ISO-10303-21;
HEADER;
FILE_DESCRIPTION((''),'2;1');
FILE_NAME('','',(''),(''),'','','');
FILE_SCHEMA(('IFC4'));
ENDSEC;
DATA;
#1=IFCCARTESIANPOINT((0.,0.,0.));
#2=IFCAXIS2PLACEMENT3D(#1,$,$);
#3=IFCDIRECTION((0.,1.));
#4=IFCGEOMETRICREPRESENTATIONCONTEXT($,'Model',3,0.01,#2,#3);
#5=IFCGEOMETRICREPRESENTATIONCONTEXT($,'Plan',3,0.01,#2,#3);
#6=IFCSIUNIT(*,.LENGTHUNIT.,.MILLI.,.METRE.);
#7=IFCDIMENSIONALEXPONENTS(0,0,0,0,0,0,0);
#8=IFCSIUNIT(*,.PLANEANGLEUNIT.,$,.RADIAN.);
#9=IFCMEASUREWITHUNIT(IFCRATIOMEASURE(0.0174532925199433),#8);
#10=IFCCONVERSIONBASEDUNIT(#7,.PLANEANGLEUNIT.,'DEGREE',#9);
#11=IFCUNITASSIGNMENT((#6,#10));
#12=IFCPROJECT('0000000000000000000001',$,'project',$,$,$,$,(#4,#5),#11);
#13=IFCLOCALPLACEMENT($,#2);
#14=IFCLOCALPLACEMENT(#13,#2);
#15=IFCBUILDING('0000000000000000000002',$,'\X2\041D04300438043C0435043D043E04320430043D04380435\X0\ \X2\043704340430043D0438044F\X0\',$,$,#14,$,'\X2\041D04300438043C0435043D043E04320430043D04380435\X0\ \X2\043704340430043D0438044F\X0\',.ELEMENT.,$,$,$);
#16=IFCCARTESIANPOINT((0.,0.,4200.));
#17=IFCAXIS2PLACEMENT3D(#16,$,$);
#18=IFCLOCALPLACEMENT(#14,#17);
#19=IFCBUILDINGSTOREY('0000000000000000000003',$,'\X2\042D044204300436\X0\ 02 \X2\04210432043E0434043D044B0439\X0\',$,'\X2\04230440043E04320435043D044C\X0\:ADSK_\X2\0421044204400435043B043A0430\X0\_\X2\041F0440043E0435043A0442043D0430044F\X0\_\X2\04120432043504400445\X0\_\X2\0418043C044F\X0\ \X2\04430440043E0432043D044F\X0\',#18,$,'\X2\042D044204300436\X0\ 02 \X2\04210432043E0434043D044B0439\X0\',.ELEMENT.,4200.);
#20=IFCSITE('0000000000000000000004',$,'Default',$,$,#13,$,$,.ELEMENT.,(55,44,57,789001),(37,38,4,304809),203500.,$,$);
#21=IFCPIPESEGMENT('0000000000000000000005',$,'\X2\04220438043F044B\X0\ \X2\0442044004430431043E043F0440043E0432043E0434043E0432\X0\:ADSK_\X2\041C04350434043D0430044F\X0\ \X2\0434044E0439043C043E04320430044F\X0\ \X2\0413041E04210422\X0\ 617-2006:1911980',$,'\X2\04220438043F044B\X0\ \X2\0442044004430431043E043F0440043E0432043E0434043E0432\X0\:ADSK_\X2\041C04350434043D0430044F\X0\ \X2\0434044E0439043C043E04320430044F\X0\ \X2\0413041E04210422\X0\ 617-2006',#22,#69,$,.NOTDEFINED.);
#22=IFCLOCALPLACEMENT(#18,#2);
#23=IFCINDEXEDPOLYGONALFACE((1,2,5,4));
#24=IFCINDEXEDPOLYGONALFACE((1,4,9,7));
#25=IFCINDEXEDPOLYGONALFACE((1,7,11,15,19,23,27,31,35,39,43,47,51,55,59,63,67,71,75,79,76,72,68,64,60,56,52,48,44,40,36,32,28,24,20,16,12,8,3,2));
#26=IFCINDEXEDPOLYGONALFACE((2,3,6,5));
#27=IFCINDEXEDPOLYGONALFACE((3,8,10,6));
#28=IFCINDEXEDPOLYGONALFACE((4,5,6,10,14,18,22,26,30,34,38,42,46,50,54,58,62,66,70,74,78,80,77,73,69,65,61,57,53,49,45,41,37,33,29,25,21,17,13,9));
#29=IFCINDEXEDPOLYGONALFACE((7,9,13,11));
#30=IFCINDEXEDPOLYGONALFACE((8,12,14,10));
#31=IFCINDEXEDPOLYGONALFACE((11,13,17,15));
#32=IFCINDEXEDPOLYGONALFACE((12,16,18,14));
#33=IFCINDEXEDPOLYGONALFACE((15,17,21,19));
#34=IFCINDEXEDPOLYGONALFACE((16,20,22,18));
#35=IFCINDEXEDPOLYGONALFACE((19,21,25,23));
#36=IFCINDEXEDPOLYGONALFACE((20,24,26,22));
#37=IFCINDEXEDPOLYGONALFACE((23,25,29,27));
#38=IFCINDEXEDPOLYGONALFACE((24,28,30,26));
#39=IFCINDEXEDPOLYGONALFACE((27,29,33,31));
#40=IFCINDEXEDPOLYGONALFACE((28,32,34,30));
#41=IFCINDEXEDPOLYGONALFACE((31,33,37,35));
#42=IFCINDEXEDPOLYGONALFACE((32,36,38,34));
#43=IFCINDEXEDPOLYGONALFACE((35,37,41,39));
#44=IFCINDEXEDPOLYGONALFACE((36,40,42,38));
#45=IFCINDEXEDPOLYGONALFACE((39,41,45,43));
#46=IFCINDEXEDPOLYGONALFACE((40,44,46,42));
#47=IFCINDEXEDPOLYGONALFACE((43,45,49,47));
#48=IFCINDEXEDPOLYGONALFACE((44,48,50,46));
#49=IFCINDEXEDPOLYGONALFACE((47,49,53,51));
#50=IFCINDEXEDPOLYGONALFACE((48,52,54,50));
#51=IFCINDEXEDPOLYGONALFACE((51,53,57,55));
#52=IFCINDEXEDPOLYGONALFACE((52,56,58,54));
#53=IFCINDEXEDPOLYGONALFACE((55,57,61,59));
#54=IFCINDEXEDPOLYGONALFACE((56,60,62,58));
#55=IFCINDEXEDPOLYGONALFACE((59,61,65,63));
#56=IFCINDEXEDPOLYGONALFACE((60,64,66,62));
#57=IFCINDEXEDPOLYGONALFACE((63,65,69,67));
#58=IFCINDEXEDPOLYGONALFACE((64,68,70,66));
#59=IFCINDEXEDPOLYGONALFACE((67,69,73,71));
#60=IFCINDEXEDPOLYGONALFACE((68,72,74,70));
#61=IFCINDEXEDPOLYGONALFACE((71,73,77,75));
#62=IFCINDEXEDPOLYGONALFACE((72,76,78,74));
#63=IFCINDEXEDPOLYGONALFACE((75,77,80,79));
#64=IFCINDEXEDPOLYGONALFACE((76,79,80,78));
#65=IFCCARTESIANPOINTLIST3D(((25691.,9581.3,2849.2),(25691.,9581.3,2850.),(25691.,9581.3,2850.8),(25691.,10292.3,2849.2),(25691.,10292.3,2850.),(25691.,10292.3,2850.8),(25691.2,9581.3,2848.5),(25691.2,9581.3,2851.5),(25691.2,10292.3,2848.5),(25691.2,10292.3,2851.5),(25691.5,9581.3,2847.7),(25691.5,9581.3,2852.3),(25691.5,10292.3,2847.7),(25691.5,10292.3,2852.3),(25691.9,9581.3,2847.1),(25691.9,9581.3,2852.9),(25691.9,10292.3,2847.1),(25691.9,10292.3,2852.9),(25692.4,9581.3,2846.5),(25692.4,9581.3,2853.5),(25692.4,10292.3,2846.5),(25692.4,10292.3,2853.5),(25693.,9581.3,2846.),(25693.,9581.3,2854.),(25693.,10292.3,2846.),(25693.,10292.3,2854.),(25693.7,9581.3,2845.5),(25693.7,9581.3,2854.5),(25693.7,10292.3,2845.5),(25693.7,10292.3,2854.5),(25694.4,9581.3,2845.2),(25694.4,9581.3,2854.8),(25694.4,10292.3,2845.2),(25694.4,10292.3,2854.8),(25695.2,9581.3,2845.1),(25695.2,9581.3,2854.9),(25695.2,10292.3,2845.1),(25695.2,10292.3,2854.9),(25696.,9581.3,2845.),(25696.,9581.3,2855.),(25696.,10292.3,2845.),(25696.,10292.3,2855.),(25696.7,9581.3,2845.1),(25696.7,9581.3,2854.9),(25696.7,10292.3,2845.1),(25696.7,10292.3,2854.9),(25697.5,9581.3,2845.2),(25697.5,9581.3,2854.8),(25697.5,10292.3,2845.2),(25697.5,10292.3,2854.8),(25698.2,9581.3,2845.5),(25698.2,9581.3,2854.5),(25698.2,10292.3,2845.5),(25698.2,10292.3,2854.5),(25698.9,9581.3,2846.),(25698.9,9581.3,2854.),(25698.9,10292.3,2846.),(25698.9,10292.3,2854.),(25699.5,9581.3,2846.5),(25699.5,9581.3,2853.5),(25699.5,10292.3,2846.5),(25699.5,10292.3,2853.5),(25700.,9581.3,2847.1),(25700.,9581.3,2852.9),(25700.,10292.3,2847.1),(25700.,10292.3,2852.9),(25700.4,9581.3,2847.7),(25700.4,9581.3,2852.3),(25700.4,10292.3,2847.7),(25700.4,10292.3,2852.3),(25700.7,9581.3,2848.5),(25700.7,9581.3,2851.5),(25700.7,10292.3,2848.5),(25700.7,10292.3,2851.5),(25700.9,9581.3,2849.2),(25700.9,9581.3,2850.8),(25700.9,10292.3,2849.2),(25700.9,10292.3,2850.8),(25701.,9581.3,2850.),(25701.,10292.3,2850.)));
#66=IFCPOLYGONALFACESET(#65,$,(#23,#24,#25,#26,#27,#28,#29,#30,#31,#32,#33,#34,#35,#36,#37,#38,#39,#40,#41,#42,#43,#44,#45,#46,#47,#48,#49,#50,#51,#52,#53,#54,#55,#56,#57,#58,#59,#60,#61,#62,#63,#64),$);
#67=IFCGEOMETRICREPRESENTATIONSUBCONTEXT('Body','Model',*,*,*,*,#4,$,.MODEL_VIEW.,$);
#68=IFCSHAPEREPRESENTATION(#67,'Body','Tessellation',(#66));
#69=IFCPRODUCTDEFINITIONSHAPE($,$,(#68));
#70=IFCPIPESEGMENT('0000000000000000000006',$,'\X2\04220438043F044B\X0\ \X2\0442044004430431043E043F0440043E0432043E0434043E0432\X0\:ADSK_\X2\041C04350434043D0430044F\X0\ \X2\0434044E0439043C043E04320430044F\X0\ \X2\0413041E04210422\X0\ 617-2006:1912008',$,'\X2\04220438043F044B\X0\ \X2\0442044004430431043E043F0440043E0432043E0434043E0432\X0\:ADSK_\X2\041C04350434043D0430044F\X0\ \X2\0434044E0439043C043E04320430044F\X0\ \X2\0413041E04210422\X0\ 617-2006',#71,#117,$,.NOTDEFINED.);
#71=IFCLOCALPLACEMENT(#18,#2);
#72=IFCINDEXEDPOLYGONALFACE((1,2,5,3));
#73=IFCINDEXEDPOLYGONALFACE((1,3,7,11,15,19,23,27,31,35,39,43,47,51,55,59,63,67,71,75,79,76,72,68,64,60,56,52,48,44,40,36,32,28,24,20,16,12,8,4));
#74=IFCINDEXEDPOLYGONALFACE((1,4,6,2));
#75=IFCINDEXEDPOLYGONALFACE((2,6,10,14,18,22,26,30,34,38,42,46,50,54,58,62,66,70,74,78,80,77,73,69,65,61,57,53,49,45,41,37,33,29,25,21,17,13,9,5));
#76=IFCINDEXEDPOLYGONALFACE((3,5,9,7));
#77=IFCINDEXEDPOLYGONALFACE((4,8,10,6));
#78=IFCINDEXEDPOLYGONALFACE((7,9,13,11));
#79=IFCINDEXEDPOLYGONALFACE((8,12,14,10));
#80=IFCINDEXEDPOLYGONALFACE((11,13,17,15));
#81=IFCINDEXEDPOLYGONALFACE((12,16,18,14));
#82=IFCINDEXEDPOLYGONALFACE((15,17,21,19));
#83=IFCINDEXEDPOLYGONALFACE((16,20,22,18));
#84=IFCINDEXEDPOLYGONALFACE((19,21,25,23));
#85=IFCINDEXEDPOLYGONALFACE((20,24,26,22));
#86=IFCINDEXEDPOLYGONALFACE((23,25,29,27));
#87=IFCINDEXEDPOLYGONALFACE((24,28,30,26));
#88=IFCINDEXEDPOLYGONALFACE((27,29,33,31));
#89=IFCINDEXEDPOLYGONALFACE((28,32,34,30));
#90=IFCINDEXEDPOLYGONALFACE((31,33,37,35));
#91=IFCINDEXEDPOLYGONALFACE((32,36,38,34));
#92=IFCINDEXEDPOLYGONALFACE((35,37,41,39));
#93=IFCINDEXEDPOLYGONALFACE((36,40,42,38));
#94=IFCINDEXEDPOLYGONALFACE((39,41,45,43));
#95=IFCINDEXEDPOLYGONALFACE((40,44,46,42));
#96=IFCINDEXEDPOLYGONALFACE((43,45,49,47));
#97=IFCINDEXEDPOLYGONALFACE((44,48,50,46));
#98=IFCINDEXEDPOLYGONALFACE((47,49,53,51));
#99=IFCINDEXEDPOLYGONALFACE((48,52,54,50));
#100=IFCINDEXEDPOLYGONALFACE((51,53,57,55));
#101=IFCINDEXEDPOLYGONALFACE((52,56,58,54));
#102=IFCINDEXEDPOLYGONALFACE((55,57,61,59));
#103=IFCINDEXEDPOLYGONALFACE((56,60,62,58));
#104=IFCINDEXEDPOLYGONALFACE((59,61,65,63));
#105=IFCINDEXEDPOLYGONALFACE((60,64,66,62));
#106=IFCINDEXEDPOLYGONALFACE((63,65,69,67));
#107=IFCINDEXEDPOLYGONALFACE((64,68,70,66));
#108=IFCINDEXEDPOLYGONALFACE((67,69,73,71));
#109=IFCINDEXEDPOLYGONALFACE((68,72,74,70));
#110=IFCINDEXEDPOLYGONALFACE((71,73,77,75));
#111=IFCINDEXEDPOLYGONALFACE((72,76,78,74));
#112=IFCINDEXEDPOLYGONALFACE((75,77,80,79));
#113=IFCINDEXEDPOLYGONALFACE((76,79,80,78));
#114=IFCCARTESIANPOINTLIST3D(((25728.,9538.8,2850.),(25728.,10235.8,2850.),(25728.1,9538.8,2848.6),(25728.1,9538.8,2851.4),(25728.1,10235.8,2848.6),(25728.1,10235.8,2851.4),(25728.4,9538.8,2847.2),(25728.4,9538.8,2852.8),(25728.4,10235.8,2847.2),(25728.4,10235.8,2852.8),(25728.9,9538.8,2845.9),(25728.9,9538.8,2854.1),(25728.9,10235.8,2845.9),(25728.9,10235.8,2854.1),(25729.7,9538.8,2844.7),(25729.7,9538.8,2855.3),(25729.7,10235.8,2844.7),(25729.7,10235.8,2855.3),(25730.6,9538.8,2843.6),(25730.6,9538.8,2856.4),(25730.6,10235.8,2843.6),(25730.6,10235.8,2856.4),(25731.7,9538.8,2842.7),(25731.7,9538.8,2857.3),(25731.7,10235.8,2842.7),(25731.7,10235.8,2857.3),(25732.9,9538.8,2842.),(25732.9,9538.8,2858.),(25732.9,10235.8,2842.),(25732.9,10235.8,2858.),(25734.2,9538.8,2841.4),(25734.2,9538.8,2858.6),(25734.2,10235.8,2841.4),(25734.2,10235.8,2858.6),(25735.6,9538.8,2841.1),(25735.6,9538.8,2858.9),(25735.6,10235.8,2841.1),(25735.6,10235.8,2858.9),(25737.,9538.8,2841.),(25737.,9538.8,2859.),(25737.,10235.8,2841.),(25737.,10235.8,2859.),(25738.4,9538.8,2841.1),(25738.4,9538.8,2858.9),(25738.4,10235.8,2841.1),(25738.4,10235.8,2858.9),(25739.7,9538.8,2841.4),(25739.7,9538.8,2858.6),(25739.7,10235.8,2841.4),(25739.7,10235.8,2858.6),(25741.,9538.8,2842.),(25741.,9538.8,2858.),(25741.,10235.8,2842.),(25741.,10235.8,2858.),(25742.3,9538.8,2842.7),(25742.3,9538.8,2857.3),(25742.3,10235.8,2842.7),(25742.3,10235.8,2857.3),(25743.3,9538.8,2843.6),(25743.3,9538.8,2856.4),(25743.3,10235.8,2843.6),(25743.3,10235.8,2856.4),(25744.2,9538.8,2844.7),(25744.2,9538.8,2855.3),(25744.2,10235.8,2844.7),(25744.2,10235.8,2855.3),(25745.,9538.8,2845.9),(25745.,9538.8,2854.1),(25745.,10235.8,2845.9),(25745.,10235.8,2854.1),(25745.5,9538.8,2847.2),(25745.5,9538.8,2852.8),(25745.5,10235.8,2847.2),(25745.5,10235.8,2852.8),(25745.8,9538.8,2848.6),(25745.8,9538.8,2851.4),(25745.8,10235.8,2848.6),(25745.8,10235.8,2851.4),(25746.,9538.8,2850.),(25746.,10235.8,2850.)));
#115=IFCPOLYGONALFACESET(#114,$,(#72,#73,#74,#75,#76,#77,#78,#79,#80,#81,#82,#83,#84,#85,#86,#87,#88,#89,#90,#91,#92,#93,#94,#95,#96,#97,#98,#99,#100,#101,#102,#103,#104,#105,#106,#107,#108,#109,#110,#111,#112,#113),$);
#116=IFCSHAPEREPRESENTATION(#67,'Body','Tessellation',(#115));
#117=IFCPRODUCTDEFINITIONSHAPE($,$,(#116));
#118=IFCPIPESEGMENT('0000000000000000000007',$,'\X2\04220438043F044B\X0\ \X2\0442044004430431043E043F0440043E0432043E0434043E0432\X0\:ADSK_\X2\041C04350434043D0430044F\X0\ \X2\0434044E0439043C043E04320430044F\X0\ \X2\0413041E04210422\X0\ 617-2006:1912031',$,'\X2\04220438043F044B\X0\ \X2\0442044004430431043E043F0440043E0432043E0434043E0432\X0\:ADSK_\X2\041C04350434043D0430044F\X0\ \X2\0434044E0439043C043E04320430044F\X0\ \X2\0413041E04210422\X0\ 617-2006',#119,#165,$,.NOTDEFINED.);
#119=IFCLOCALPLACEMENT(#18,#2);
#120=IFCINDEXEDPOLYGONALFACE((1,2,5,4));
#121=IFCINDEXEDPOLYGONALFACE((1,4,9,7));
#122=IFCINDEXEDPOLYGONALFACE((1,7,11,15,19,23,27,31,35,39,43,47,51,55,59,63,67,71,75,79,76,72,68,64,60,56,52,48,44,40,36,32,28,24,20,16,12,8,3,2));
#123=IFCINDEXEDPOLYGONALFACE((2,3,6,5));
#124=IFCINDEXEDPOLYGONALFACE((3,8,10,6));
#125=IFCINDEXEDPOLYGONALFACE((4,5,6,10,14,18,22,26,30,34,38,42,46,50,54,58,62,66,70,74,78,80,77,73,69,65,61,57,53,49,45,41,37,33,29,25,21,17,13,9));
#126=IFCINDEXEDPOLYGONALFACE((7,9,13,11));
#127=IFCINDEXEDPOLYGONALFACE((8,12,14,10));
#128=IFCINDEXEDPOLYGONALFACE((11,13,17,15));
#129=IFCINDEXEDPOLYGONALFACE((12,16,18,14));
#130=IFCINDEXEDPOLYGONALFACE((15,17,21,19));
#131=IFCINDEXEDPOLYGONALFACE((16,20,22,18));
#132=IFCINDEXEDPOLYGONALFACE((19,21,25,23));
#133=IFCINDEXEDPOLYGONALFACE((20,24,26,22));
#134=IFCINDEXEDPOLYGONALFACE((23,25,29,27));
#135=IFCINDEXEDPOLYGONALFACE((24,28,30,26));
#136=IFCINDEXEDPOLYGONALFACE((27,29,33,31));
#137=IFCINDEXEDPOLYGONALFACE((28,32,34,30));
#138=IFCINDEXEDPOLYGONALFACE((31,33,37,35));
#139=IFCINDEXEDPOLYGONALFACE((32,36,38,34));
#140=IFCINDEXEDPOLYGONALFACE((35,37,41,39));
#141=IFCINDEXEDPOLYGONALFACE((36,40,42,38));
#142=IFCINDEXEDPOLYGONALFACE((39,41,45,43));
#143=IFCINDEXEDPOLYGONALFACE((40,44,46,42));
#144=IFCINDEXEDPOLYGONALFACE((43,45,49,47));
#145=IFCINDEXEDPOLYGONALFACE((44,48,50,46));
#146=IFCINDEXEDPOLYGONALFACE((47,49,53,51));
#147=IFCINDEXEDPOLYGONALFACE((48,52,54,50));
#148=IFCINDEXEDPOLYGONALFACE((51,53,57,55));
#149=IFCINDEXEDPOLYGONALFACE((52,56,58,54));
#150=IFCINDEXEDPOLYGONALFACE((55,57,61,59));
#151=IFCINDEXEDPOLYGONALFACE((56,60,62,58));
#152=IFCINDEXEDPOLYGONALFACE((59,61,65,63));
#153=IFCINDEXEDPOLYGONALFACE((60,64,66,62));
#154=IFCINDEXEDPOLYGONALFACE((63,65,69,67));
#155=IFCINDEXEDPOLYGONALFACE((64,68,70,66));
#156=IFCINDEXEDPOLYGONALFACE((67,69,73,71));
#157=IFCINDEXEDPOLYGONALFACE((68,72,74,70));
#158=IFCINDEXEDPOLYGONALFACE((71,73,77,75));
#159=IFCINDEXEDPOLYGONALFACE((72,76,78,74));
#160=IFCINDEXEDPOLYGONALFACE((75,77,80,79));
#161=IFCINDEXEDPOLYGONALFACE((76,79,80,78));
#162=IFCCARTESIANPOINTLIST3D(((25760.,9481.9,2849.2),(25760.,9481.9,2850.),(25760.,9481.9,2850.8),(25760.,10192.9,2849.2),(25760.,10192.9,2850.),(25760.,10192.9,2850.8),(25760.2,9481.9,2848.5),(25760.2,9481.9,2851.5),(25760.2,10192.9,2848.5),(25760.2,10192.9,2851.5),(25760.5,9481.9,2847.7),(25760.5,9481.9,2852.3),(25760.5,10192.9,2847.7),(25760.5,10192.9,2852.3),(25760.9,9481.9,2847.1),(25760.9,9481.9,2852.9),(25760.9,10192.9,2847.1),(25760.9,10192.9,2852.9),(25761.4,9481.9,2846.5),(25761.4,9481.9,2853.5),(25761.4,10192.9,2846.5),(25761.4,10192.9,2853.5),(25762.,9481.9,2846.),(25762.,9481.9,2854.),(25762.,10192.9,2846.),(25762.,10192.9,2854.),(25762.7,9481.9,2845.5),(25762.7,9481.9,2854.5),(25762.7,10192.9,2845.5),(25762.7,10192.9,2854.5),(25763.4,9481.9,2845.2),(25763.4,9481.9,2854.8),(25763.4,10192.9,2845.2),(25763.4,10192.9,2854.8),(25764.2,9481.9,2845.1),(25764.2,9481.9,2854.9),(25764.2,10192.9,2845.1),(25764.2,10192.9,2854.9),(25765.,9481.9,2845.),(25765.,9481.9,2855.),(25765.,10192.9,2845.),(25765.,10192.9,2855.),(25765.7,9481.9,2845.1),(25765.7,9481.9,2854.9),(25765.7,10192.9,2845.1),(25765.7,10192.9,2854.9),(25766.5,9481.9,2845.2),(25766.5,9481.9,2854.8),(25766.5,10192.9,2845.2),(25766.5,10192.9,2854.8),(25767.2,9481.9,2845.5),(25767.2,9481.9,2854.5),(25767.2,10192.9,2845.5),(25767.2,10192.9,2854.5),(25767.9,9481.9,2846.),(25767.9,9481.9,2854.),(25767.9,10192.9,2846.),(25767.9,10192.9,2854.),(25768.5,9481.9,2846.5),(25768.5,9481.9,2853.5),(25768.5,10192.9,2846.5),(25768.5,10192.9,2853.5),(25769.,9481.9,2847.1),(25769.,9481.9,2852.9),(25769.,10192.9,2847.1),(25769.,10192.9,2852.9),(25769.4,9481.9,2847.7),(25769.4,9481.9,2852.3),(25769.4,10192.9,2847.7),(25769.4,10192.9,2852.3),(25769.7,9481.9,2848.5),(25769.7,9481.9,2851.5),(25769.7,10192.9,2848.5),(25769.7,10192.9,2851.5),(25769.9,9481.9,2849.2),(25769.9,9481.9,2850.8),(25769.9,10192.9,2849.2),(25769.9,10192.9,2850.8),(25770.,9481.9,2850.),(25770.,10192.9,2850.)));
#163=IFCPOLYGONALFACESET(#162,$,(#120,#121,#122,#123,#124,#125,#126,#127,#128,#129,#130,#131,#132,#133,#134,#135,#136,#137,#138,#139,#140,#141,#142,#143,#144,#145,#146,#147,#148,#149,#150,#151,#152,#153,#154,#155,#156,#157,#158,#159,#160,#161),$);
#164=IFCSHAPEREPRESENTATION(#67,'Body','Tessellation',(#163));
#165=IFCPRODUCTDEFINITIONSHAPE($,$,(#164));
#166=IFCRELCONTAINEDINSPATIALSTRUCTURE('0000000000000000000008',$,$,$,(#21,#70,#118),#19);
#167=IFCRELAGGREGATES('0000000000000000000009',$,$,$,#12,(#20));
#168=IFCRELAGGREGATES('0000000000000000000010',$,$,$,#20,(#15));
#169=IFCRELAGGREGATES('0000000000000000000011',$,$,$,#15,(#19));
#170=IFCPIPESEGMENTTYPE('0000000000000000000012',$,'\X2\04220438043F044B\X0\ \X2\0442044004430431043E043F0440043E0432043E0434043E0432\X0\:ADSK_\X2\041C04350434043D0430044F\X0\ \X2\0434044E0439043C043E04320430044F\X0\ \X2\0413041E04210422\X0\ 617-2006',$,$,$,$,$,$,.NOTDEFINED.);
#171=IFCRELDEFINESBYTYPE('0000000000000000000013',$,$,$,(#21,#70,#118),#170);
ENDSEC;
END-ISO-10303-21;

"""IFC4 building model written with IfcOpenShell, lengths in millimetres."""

from ifc_helpers import new_model, entity, si_unit, converted_unit, direction, frame, origin, place, context, subcontext, project, spatial, indexed_curve, outline, extrude, type_object, element, save


model = new_model("IFC4")

# Units and contexts
model_context = context("Model", 3, precision=0.01, world=origin(), true_north=direction((0.0, 1.0)))
plan_context = context("Plan", 3, precision=0.01, world=origin(), true_north=direction((0.0, 1.0)))
body_context = subcontext(model_context, "Body", "Model", "MODEL_VIEW")
ifc_project = project(units=[si_unit("LENGTHUNIT", "METRE", prefix="MILLI"), converted_unit("PLANEANGLEUNIT", "DEGREE", entity("IfcRatioMeasure", 0.0174532925199433), si_unit("PLANEANGLEUNIT", "RADIAN"), dimensions=[0, 0, 0, 0, 0, 0, 0])], contexts=[model_context, plan_context])

# Site, building, storey
site_placement = place(None, origin())
site = spatial("IfcSite", under=ifc_project, at=site_placement, Name="Default", CompositionType="ELEMENT", RefLatitude=(55, 44, 57, 789001), RefLongitude=(37, 38, 4, 304809), RefElevation=203500.0)
building_placement = place(site_placement, origin())
building = spatial("IfcBuilding", under=site, at=building_placement, Name="Наименование здания", LongName="Наименование здания", CompositionType="ELEMENT")
storey_placement = place(building_placement, frame((0.0, 0.0, 4200.0)))
storey = spatial("IfcBuildingStorey", under=building, at=storey_placement, Name="Этаж 02 Сводный", ObjectType="Уровень:ADSK_Стрелка_Проектная_Вверх_Имя уровня", LongName="Этаж 02 Сводный", CompositionType="ELEMENT", Elevation=4200.0)

# Pipe segments
pipe_segment_type_1 = type_object("IfcPipeSegmentType", Name="Типы трубопроводов:ADSK_Медная дюймовая ГОСТ 617-2006", PredefinedType="NOTDEFINED")
placement = place(storey_placement, origin())
element("IfcPipeSegment", 1, at=placement, inside=storey, type_object=pipe_segment_type_1, Name="Типы трубопроводов:ADSK_Медная дюймовая ГОСТ 617-2006:1911980", ObjectType="Типы трубопроводов:ADSK_Медная дюймовая ГОСТ 617-2006", PredefinedType="NOTDEFINED", context=body_context, shape_type="SweptSolid", body=[
    extrude(outline(indexed_curve([(5.0, 0.0), (4.9, 0.8), (4.8, 1.5), (4.5, 2.3), (4.0, 2.9), (3.5, 3.5), (2.9, 4.0), (2.3, 4.5), (1.5, 4.8), (0.8, 4.9), (0.0, 5.0), (-0.8, 4.9), (-1.5, 4.8), (-2.3, 4.5), (-2.9, 4.0), (-3.5, 3.5), (-4.0, 2.9), (-4.5, 2.3), (-4.8, 1.5), (-4.9, 0.8), (-5.0, 0.0), (-4.9, -0.8), (-4.8, -1.5), (-4.5, -2.3), (-4.0, -2.9), (-3.5, -3.5), (-2.9, -4.0), (-2.3, -4.5), (-1.5, -4.8), (-0.8, -4.9), (0.0, -5.0), (0.8, -4.9), (1.5, -4.8), (2.3, -4.5), (2.9, -4.0), (3.5, -3.5), (4.0, -2.9), (4.5, -2.3), (4.8, -1.5), (4.9, -0.8), (5.0, 0.0)], self_intersect=False)), frame((25696.0, 9581.3, 2850.0), z_axis=(0.0, 1.0, 0.0), x_axis=(1.0, 0.0, 0.0)), (0.0, 0.0, 1.0), 711.0),
])
element("IfcPipeSegment", 2, at=placement, inside=storey, type_object=pipe_segment_type_1, Name="Типы трубопроводов:ADSK_Медная дюймовая ГОСТ 617-2006:1912008", ObjectType="Типы трубопроводов:ADSK_Медная дюймовая ГОСТ 617-2006", PredefinedType="NOTDEFINED", context=body_context, shape_type="SweptSolid", body=[
    extrude(outline(indexed_curve([(9.0, 0.0), (8.9, 1.4), (8.6, 2.8), (8.0, 4.1), (7.3, 5.3), (6.4, 6.4), (5.3, 7.3), (4.1, 8.0), (2.8, 8.6), (1.4, 8.9), (0.0, 9.0), (-1.4, 8.9), (-2.8, 8.6), (-4.1, 8.0), (-5.3, 7.3), (-6.4, 6.4), (-7.3, 5.3), (-8.0, 4.1), (-8.6, 2.8), (-8.9, 1.4), (-9.0, 0.0), (-8.9, -1.4), (-8.6, -2.8), (-8.0, -4.1), (-7.3, -5.3), (-6.4, -6.4), (-5.3, -7.3), (-4.1, -8.0), (-2.8, -8.6), (-1.4, -8.9), (0.0, -9.0), (1.4, -8.9), (2.8, -8.6), (4.1, -8.0), (5.3, -7.3), (6.4, -6.4), (7.3, -5.3), (8.0, -4.1), (8.6, -2.8), (8.9, -1.4), (9.0, 0.0)], self_intersect=False)), frame((25737.0, 9538.8, 2850.0), z_axis=(0.0, 1.0, 0.0), x_axis=(1.0, 0.0, 0.0)), (0.0, 0.0, 1.0), 697.0),
])
element("IfcPipeSegment", 3, at=placement, inside=storey, type_object=pipe_segment_type_1, Name="Типы трубопроводов:ADSK_Медная дюймовая ГОСТ 617-2006:1912031", ObjectType="Типы трубопроводов:ADSK_Медная дюймовая ГОСТ 617-2006", PredefinedType="NOTDEFINED", context=body_context, shape_type="SweptSolid", body=[
    extrude(outline(indexed_curve([(5.0, 0.0), (4.9, 0.8), (4.8, 1.5), (4.5, 2.3), (4.0, 2.9), (3.5, 3.5), (2.9, 4.0), (2.3, 4.5), (1.5, 4.8), (0.8, 4.9), (0.0, 5.0), (-0.8, 4.9), (-1.5, 4.8), (-2.3, 4.5), (-2.9, 4.0), (-3.5, 3.5), (-4.0, 2.9), (-4.5, 2.3), (-4.8, 1.5), (-4.9, 0.8), (-5.0, 0.0), (-4.9, -0.8), (-4.8, -1.5), (-4.5, -2.3), (-4.0, -2.9), (-3.5, -3.5), (-2.9, -4.0), (-2.3, -4.5), (-1.5, -4.8), (-0.8, -4.9), (0.0, -5.0), (0.8, -4.9), (1.5, -4.8), (2.3, -4.5), (2.9, -4.0), (3.5, -3.5), (4.0, -2.9), (4.5, -2.3), (4.8, -1.5), (4.9, -0.8), (5.0, 0.0)], self_intersect=False)), frame((25765.0, 9481.9, 2850.0), z_axis=(0.0, 1.0, 0.0), x_axis=(1.0, 0.0, 0.0)), (0.0, 0.0, 1.0), 711.0),
])

save(model, "model.ifc")
